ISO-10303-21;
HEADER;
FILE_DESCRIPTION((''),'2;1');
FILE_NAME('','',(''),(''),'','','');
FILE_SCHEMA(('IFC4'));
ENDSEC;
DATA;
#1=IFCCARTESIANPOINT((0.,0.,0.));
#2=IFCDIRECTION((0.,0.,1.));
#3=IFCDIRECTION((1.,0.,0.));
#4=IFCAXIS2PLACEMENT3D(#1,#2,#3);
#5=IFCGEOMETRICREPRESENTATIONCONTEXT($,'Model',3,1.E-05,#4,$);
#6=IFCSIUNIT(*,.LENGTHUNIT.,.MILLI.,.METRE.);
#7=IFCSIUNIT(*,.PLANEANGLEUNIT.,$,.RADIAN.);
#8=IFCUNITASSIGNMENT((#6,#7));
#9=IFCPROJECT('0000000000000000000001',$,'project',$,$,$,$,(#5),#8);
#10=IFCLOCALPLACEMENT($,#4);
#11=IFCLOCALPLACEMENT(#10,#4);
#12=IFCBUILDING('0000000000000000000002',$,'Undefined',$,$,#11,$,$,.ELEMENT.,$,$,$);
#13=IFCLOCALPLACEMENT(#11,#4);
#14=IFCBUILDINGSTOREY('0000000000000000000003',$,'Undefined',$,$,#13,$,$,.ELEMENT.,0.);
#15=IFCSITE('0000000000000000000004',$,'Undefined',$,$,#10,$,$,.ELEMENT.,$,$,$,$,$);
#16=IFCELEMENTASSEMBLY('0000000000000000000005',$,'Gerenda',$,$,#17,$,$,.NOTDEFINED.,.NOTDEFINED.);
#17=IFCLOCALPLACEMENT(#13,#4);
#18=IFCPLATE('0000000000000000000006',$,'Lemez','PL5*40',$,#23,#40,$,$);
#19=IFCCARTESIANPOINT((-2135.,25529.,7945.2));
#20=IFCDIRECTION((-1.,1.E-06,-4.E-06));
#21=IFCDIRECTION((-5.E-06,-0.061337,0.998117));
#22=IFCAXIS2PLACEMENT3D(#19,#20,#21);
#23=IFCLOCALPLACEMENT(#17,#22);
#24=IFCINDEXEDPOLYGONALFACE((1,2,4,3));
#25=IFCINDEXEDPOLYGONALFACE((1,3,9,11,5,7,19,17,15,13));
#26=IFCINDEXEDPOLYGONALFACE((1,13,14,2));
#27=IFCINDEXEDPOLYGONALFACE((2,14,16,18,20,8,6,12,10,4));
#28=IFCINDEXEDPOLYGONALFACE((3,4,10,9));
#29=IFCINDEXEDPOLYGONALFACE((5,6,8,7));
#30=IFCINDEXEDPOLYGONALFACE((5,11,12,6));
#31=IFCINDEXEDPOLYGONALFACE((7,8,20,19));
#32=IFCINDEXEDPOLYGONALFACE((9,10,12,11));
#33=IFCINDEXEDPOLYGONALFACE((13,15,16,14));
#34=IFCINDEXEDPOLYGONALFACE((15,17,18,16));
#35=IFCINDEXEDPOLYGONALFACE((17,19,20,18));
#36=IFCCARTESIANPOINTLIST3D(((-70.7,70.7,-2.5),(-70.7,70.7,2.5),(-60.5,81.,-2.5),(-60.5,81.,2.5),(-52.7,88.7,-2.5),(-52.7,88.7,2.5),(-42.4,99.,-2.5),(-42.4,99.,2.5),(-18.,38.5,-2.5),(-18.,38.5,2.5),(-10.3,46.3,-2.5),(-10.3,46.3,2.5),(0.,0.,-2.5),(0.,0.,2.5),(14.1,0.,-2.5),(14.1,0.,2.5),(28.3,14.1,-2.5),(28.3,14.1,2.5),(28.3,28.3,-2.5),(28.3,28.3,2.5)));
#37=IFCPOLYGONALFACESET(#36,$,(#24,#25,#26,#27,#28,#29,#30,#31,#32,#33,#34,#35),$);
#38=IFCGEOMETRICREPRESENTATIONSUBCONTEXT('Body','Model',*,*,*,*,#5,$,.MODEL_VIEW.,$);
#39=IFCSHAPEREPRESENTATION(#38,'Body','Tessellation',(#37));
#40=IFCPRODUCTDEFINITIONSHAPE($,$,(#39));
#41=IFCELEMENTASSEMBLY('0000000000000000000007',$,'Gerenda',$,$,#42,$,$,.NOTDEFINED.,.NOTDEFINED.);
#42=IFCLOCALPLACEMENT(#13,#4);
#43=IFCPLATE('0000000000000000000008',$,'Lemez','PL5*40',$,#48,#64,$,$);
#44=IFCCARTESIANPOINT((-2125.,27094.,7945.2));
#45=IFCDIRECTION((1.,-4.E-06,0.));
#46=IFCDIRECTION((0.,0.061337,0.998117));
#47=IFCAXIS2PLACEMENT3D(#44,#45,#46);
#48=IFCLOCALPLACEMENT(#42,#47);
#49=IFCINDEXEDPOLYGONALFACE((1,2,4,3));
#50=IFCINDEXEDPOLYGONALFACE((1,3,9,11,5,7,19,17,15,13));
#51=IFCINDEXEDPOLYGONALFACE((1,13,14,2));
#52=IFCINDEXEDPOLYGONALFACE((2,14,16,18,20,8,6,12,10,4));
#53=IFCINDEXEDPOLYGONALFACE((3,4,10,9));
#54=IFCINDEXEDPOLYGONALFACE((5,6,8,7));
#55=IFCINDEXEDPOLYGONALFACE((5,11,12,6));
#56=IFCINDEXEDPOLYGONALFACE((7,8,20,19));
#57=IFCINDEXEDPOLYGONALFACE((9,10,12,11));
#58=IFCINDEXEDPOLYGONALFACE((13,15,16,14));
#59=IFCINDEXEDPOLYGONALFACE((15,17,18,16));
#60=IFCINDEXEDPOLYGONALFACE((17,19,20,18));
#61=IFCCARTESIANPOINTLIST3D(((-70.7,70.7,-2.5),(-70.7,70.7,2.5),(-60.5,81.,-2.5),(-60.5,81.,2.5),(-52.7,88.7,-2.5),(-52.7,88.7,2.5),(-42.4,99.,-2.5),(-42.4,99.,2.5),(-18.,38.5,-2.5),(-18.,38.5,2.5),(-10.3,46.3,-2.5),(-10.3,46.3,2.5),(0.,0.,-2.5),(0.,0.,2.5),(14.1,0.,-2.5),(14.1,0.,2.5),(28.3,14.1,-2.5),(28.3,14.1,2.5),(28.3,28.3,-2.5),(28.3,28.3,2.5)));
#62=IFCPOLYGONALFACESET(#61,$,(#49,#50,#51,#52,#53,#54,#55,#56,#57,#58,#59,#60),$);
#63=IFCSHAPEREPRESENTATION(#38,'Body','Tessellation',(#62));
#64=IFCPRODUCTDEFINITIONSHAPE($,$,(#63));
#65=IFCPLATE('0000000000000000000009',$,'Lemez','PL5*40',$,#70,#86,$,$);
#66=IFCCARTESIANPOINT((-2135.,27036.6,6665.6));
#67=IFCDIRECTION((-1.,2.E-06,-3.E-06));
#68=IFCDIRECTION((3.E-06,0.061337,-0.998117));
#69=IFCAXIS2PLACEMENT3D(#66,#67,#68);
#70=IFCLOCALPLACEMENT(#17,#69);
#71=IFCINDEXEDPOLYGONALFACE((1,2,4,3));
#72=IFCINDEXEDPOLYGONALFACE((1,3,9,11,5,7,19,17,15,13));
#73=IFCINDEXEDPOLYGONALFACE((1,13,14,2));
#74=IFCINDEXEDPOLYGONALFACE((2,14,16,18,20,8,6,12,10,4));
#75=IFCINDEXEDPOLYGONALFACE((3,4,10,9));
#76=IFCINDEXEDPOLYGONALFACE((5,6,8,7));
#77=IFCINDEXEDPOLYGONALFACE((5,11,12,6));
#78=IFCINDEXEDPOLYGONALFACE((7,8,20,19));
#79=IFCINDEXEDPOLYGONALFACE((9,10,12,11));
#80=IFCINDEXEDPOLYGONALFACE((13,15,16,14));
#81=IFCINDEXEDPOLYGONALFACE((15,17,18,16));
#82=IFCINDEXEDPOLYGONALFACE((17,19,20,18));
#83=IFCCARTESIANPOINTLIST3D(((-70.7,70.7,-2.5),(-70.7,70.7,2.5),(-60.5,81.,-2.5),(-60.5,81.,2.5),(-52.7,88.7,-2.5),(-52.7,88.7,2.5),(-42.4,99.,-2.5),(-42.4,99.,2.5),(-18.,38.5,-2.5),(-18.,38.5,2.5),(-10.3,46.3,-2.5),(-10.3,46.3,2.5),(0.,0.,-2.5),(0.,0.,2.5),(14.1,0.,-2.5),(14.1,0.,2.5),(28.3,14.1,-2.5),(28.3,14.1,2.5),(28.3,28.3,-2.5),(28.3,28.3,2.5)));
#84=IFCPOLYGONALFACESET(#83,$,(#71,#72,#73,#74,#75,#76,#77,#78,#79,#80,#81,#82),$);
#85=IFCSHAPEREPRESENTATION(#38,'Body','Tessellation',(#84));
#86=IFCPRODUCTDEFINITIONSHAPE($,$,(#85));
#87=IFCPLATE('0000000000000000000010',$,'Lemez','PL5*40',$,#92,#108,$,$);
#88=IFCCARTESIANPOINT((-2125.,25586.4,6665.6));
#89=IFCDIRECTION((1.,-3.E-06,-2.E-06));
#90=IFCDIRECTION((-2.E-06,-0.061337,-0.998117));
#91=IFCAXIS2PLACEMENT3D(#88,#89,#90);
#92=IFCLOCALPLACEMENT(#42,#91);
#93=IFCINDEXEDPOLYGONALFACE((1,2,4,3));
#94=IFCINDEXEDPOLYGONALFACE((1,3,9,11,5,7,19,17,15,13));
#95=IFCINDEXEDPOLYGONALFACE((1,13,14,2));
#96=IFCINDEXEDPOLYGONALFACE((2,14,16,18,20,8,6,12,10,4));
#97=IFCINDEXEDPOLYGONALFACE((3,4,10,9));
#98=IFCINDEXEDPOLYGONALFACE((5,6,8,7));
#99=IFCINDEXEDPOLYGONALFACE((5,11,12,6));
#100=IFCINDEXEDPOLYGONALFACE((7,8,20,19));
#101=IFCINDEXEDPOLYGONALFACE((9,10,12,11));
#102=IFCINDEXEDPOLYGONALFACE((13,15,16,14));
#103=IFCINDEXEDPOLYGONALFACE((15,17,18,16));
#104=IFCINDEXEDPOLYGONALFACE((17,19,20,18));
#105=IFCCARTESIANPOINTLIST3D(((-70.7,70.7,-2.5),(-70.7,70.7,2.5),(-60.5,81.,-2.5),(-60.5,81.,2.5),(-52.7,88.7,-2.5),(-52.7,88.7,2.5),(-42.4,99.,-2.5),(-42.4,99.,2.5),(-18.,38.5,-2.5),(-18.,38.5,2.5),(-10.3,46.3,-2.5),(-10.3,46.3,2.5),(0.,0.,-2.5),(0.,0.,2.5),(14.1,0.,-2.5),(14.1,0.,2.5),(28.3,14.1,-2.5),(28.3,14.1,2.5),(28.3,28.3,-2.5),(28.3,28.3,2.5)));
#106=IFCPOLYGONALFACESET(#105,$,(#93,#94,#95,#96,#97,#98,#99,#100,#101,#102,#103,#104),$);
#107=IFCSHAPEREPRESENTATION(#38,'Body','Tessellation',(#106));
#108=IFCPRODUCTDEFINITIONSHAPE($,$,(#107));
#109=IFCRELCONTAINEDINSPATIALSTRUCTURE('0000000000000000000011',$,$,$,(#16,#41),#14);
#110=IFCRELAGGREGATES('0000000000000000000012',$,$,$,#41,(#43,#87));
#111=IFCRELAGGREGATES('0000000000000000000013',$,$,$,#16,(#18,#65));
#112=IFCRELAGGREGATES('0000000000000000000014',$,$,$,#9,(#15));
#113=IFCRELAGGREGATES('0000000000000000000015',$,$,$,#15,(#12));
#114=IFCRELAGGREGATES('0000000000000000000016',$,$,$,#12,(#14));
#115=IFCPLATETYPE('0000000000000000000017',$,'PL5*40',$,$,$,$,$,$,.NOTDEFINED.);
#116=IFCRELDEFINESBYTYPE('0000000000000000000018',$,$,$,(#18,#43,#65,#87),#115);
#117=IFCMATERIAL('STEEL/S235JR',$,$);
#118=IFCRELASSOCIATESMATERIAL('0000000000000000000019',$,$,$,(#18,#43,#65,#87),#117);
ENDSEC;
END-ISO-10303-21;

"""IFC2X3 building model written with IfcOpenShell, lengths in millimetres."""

from ifc_helpers import new_model, si_unit, frame, origin_with_axes, place, context, subcontext, project, spatial, polyline, outline, extrude, material, type_object, element, aggregate, save


model = new_model("IFC2X3")

# Units and contexts
model_context = context("Model", 3, precision=1e-05, world=origin_with_axes())
body_context = subcontext(model_context, "Body", "Model", "MODEL_VIEW")
ifc_project = project(units=[si_unit("LENGTHUNIT", "METRE", prefix="MILLI"), si_unit("PLANEANGLEUNIT", "RADIAN")], contexts=[model_context])

# Site, building, storey
site_placement = place(None, origin_with_axes())
site = spatial("IfcSite", under=ifc_project, at=site_placement, Name="Undefined", CompositionType="ELEMENT")
building_placement = place(site_placement, origin_with_axes())
building = spatial("IfcBuilding", under=site, at=building_placement, Name="Undefined", CompositionType="ELEMENT")
storey_placement = place(building_placement, origin_with_axes())
storey = spatial("IfcBuildingStorey", under=building, at=storey_placement, Name="Undefined", CompositionType="ELEMENT", Elevation=0.0)

# Element assemblies, plates
assembly_1_placement = place(storey_placement, origin_with_axes())
assembly_1 = element("IfcElementAssembly", 1, at=assembly_1_placement, inside=storey, Name="Gerenda", AssemblyPlace="NOTDEFINED", PredefinedType="NOTDEFINED")
ifc_material_1 = material(Name="STEEL/S235JR")
plate_type_1 = type_object("IfcPlateType", Name="PL5*40", PredefinedType="NOTDEFINED")
plate_1_placement = place(assembly_1_placement, frame((-2135.0, 25529.0, 7945.2), z_axis=(-1.0, 0.000001, -0.000004), x_axis=(-0.000005, -0.061337, 0.998117)))
plate_1 = element("IfcPlate", 2, at=plate_1_placement, type_object=plate_type_1, material=ifc_material_1, Name="Lemez", Description="PL5*40", context=body_context, shape_type="SweptSolid", body=[
    extrude(outline(polyline([(0.0, 0.0), (14.1, 0.0), (28.3, 14.1), (28.3, 28.3), (-42.4, 99.0), (-52.7, 88.7), (-10.3, 46.3), (-18.0, 38.5), (-60.5, 81.0), (-70.7, 70.7), (0.0, 0.0)])), frame((0.0, 0.0, -2.5), z_axis=(0.0, 0.0, 1.0), x_axis=(1.0, 0.0, 0.0)), (0.0, 0.0, 1.0), 5.0),
])
assembly_2_placement = place(storey_placement, origin_with_axes())
assembly_2 = element("IfcElementAssembly", 3, at=assembly_2_placement, inside=storey, Name="Gerenda", AssemblyPlace="NOTDEFINED", PredefinedType="NOTDEFINED")
plate_2_placement = place(assembly_2_placement, frame((-2125.0, 27094.0, 7945.2), z_axis=(1.0, -0.000004, 0.0), x_axis=(0.0, 0.061337, 0.998117)))
plate_2 = element("IfcPlate", 4, at=plate_2_placement, type_object=plate_type_1, material=ifc_material_1, Name="Lemez", Description="PL5*40", context=body_context, shape_type="SweptSolid", body=[
    extrude(outline(polyline([(0.0, 0.0), (14.1, 0.0), (28.3, 14.1), (28.3, 28.3), (-42.4, 99.0), (-52.7, 88.7), (-10.3, 46.3), (-18.0, 38.5), (-60.5, 81.0), (-70.7, 70.7), (0.0, 0.0)])), frame((0.0, 0.0, -2.5), z_axis=(0.0, 0.0, 1.0), x_axis=(1.0, 0.0, 0.0)), (0.0, 0.0, 1.0), 5.0),
])

# Plates
plate_3_placement = place(assembly_1_placement, frame((-2135.0, 27036.6, 6665.6), z_axis=(-1.0, 0.000002, -0.000003), x_axis=(0.000003, 0.061337, -0.998117)))
plate_3 = element("IfcPlate", 5, at=plate_3_placement, type_object=plate_type_1, material=ifc_material_1, Name="Lemez", Description="PL5*40", context=body_context, shape_type="SweptSolid", body=[
    extrude(outline(polyline([(0.0, 0.0), (14.1, 0.0), (28.3, 14.1), (28.3, 28.3), (-42.4, 99.0), (-52.7, 88.7), (-10.3, 46.3), (-18.0, 38.5), (-60.5, 81.0), (-70.7, 70.7), (0.0, 0.0)])), frame((0.0, 0.0, -2.5), z_axis=(0.0, 0.0, 1.0), x_axis=(1.0, 0.0, 0.0)), (0.0, 0.0, 1.0), 5.0),
])
plate_4_placement = place(assembly_2_placement, frame((-2125.0, 25586.4, 6665.6), z_axis=(1.0, -0.000003, -0.000002), x_axis=(-0.000002, -0.061337, -0.998117)))
plate_4 = element("IfcPlate", 6, at=plate_4_placement, type_object=plate_type_1, material=ifc_material_1, Name="Lemez", Description="PL5*40", context=body_context, shape_type="SweptSolid", body=[
    extrude(outline(polyline([(0.0, 0.0), (14.1, 0.0), (28.3, 14.1), (28.3, 28.3), (-42.4, 99.0), (-52.7, 88.7), (-10.3, 46.3), (-18.0, 38.5), (-60.5, 81.0), (-70.7, 70.7), (0.0, 0.0)])), frame((0.0, 0.0, -2.5), z_axis=(0.0, 0.0, 1.0), x_axis=(1.0, 0.0, 0.0)), (0.0, 0.0, 1.0), 5.0),
])

aggregate(assembly_2, [plate_2, plate_4])
aggregate(assembly_1, [plate_1, plate_3])

save(model, "model.ifc")
